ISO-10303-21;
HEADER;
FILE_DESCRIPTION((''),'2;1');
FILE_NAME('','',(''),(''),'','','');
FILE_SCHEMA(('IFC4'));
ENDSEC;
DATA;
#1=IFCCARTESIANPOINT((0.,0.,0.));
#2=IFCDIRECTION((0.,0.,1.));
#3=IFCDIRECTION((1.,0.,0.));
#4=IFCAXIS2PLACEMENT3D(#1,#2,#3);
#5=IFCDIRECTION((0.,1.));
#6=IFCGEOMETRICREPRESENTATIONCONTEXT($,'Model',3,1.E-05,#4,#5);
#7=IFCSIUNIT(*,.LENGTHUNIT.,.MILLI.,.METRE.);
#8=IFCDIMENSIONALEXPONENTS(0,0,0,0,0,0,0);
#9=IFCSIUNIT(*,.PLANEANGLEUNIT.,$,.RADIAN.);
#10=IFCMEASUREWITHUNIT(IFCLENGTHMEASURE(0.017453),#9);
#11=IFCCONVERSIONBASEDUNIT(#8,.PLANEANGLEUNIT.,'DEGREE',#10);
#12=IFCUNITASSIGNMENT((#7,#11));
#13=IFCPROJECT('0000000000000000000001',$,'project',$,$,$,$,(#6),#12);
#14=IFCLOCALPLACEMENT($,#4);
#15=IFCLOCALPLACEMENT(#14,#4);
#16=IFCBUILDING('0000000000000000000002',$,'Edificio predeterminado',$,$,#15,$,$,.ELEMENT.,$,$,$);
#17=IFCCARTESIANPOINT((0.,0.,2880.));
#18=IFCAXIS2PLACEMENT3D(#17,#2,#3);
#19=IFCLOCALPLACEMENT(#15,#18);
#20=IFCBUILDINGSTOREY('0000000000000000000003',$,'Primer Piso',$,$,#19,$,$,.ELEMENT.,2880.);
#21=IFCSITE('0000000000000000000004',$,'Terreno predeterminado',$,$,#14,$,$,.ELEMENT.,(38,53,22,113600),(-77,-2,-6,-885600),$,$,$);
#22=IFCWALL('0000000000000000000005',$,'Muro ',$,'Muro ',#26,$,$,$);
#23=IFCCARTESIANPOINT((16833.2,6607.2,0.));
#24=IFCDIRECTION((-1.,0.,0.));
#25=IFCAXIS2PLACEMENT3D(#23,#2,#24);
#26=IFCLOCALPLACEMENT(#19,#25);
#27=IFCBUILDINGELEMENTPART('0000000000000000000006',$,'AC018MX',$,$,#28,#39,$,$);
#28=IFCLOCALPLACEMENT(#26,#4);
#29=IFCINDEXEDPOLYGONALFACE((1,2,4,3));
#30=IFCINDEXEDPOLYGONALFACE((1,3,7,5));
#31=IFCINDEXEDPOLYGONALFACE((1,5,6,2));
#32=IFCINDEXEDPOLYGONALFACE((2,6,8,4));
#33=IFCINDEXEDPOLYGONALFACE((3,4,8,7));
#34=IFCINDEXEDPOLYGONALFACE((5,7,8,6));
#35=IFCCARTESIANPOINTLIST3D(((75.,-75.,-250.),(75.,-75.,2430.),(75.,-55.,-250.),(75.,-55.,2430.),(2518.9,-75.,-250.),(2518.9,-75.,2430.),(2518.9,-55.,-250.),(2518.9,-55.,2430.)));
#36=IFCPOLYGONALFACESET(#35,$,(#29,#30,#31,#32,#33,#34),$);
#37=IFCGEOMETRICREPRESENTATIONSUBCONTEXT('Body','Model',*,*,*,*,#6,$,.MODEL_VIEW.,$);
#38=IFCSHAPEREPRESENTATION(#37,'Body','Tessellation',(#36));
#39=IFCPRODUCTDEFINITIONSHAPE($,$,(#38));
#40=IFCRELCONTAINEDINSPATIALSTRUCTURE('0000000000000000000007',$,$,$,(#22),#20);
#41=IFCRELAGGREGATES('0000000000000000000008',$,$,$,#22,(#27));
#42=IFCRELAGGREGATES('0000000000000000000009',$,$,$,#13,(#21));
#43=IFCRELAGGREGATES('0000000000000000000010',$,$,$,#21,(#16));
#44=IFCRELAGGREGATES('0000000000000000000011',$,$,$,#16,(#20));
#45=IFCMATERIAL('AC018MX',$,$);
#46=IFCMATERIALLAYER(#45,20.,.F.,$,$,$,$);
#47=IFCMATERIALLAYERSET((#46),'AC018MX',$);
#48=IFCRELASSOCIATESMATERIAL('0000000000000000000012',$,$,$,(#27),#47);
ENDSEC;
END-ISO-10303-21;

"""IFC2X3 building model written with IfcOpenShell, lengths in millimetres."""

from ifc_helpers import new_model, entity, si_unit, converted_unit, direction, frame, origin_with_axes, place, context, subcontext, project, spatial, polyline, outline, extrude, material, layer, layer_set, layer_usage, element, aggregate, save


model = new_model("IFC2X3")

# Units and contexts
model_context = context("Model", 3, precision=1e-05, world=origin_with_axes(), true_north=direction((0.0, 1.0)))
body_context = subcontext(model_context, "Body", "Model", "MODEL_VIEW")
ifc_project = project(units=[si_unit("LENGTHUNIT", "METRE", prefix="MILLI"), converted_unit("PLANEANGLEUNIT", "DEGREE", entity("IfcLengthMeasure", 0.017453), si_unit("PLANEANGLEUNIT", "RADIAN"), dimensions=[0, 0, 0, 0, 0, 0, 0])], contexts=[model_context])

# Site, building, storey
site_placement = place(None, origin_with_axes())
site = spatial("IfcSite", under=ifc_project, at=site_placement, Name="Terreno predeterminado", CompositionType="ELEMENT", RefLatitude=(38, 53, 22, 113600), RefLongitude=(-77, -2, -6, -885600))
building_placement = place(site_placement, origin_with_axes())
building = spatial("IfcBuilding", under=site, at=building_placement, Name="Edificio predeterminado", CompositionType="ELEMENT")
storey_placement = place(building_placement, frame((0.0, 0.0, 2880.0), z_axis=(0.0, 0.0, 1.0), x_axis=(1.0, 0.0, 0.0)))
storey = spatial("IfcBuildingStorey", under=building, at=storey_placement, Name="Primer Piso", CompositionType="ELEMENT", Elevation=2880.0)

# Wall, building element part
wall_1_placement = place(storey_placement, frame((16833.2, 6607.2, 0.0), z_axis=(0.0, 0.0, 1.0), x_axis=(-1.0, 0.0, 0.0)))
wall_1 = element("IfcWall", 1, at=wall_1_placement, inside=storey, Name="Muro ", ObjectType="Muro ")
ifc_material_1 = material(Name="AC018MX")
ifc_layer_1 = layer(ifc_material_1, 20.0, ventilated=False)
ifc_layer_set_1 = layer_set([ifc_layer_1], Name="AC018MX")
ifc_layer_usage_1 = layer_usage(ifc_layer_set_1, "AXIS2", "NEGATIVE", 55.0)
building_element_part_1_placement = place(wall_1_placement, origin_with_axes())
building_element_part_1 = element("IfcBuildingElementPart", 2, at=building_element_part_1_placement, material=ifc_layer_usage_1, Name="AC018MX", context=body_context, shape_type="SweptSolid", body=[
    extrude(outline(polyline([(2518.9, -55.0), (2518.9, -75.0), (75.0, -75.0), (75.0, -55.0), (2518.9, -55.0)])), frame((0.0, 0.0, -250.0), z_axis=(0.0, 0.0, 1.0), x_axis=(1.0, 0.0, 0.0)), (0.0, 0.0, 1.0), 2680.0),
])
aggregate(wall_1, [building_element_part_1])

save(model, "model.ifc")
